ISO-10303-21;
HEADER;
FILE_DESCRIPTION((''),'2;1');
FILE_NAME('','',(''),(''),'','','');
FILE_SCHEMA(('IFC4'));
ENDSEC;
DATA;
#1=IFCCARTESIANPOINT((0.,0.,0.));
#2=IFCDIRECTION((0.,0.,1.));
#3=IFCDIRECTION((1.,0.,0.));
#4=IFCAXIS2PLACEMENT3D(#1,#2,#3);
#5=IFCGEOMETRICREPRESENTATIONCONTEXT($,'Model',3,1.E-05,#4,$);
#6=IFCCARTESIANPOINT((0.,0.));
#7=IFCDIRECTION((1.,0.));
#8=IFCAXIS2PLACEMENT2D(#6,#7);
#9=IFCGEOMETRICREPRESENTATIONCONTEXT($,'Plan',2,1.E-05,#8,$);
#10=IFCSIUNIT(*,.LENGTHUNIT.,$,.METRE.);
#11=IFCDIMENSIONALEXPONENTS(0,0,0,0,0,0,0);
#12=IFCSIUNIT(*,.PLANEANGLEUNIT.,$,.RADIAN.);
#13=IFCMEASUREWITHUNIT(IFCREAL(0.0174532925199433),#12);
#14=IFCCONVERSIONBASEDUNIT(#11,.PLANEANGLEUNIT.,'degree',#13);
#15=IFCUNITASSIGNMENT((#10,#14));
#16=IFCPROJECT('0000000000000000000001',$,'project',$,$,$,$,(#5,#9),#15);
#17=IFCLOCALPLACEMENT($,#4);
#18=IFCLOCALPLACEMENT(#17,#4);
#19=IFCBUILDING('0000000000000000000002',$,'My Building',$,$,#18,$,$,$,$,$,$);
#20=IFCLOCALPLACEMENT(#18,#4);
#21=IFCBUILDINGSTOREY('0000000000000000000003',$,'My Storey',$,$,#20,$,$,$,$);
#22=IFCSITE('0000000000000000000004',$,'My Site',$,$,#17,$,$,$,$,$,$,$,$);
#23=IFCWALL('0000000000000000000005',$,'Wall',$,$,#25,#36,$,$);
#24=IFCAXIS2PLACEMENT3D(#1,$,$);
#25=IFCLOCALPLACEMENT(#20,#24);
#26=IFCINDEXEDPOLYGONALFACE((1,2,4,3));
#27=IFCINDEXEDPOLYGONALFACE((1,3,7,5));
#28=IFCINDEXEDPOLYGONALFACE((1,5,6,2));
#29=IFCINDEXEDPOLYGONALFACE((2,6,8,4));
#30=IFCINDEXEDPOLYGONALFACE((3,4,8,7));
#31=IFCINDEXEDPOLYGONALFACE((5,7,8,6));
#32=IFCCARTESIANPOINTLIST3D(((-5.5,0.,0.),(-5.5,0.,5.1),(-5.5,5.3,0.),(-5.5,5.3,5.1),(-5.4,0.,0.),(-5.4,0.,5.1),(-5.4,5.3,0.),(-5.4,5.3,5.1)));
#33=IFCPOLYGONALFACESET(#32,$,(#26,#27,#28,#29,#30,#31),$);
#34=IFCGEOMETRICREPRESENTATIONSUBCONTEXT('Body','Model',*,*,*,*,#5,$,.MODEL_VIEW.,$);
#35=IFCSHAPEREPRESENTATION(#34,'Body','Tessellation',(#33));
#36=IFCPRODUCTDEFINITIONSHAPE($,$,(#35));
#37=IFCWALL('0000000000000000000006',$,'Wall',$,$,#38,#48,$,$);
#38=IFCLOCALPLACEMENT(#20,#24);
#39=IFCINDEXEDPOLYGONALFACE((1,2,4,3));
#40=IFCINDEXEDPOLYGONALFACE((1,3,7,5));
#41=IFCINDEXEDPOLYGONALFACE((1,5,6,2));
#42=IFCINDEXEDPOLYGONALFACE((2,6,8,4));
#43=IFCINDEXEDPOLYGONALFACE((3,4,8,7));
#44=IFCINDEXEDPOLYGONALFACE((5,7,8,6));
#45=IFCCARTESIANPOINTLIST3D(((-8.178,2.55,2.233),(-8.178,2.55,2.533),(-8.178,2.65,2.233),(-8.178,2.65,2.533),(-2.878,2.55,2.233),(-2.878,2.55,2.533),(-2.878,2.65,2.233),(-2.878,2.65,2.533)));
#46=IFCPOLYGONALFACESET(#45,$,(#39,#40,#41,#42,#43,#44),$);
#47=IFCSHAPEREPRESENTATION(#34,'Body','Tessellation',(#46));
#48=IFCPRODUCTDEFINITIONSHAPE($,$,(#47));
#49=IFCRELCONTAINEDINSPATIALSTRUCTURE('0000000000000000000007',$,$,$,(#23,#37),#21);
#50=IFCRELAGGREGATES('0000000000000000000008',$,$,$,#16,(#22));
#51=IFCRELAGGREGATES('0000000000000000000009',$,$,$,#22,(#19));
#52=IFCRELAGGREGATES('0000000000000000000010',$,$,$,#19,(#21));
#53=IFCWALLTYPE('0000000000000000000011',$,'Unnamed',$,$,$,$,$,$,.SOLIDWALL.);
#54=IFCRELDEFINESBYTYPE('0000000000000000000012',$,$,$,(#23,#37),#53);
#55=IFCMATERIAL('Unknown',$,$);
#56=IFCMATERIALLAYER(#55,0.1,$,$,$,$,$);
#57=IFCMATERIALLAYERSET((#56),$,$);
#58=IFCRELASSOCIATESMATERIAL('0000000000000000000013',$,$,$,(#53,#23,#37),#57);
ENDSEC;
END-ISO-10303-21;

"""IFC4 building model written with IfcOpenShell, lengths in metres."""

from ifc_helpers import new_model, entity, si_unit, converted_unit, frame, origin_with_axes, origin_2d_with_axis, place, context, subcontext, project, spatial, indexed_curve, outline, extrude, material, layer, layer_set, layer_usage, type_object, element, save


model = new_model("IFC4")

# Units and contexts
model_context = context("Model", 3, precision=1e-05, world=origin_with_axes())
plan_context = context("Plan", 2, precision=1e-05, world=origin_2d_with_axis())
body_context = subcontext(model_context, "Body", "Model", "MODEL_VIEW")
ifc_project = project(units=[si_unit("LENGTHUNIT", "METRE"), converted_unit("PLANEANGLEUNIT", "degree", entity("IfcReal", 0.0174532925199433), si_unit("PLANEANGLEUNIT", "RADIAN"), dimensions=[0, 0, 0, 0, 0, 0, 0])], contexts=[model_context, plan_context])

# Site, building, storey
site_placement = place(None, origin_with_axes())
site = spatial("IfcSite", under=ifc_project, at=site_placement, Name="My Site")
building_placement = place(site_placement, origin_with_axes())
building = spatial("IfcBuilding", under=site, at=building_placement, Name="My Building")
storey_placement = place(building_placement, origin_with_axes())
storey = spatial("IfcBuildingStorey", under=building, at=storey_placement, Name="My Storey")

# Walls
ifc_material = material(Name="Unknown")
ifc_layer = layer(ifc_material, 0.1)
ifc_layer_set = layer_set([ifc_layer])
ifc_layer_usage_1 = layer_usage(ifc_layer_set, "AXIS2", "POSITIVE", 0.0)
wall_type = type_object("IfcWallType", Name="Unnamed", PredefinedType="SOLIDWALL", material=ifc_layer_set)
wall_1_placement = place(storey_placement, frame((-5.4, 0.0, 0.0), z_axis=(0.0, 0.0, 1.0), x_axis=(0.000001, 1.0, 0.0)))
element("IfcWall", 1, at=wall_1_placement, inside=storey, type_object=wall_type, material=ifc_layer_usage_1, Name="Wall", context=body_context, shape_type="SweptSolid", body=[
    extrude(outline(indexed_curve([(0.0, 0.0), (0.0, 0.1), (5.3, 0.1), (5.3, 0.0), (0.0, 0.0)], self_intersect=False)), origin_with_axes(), (0.0, 0.0, 1.0), 5.1),
])
ifc_layer_usage_2 = layer_usage(ifc_layer_set, "AXIS2", "POSITIVE", 0.0)
wall_2_placement = place(storey_placement, frame((-2.878, 2.65, 2.233), z_axis=(0.0, 0.0, 1.0), x_axis=(-1.0, 0.000001, 0.0)))
element("IfcWall", 2, at=wall_2_placement, inside=storey, type_object=wall_type, material=ifc_layer_usage_2, Name="Wall", context=body_context, shape_type="SweptSolid", body=[
    extrude(outline(indexed_curve([(0.0, 0.0), (0.0, 0.1), (5.3, 0.1), (5.3, 0.0), (0.0, 0.0)], self_intersect=False)), origin_with_axes(), (0.0, 0.0, 1.0), 0.3),
])

save(model, "model.ifc")
